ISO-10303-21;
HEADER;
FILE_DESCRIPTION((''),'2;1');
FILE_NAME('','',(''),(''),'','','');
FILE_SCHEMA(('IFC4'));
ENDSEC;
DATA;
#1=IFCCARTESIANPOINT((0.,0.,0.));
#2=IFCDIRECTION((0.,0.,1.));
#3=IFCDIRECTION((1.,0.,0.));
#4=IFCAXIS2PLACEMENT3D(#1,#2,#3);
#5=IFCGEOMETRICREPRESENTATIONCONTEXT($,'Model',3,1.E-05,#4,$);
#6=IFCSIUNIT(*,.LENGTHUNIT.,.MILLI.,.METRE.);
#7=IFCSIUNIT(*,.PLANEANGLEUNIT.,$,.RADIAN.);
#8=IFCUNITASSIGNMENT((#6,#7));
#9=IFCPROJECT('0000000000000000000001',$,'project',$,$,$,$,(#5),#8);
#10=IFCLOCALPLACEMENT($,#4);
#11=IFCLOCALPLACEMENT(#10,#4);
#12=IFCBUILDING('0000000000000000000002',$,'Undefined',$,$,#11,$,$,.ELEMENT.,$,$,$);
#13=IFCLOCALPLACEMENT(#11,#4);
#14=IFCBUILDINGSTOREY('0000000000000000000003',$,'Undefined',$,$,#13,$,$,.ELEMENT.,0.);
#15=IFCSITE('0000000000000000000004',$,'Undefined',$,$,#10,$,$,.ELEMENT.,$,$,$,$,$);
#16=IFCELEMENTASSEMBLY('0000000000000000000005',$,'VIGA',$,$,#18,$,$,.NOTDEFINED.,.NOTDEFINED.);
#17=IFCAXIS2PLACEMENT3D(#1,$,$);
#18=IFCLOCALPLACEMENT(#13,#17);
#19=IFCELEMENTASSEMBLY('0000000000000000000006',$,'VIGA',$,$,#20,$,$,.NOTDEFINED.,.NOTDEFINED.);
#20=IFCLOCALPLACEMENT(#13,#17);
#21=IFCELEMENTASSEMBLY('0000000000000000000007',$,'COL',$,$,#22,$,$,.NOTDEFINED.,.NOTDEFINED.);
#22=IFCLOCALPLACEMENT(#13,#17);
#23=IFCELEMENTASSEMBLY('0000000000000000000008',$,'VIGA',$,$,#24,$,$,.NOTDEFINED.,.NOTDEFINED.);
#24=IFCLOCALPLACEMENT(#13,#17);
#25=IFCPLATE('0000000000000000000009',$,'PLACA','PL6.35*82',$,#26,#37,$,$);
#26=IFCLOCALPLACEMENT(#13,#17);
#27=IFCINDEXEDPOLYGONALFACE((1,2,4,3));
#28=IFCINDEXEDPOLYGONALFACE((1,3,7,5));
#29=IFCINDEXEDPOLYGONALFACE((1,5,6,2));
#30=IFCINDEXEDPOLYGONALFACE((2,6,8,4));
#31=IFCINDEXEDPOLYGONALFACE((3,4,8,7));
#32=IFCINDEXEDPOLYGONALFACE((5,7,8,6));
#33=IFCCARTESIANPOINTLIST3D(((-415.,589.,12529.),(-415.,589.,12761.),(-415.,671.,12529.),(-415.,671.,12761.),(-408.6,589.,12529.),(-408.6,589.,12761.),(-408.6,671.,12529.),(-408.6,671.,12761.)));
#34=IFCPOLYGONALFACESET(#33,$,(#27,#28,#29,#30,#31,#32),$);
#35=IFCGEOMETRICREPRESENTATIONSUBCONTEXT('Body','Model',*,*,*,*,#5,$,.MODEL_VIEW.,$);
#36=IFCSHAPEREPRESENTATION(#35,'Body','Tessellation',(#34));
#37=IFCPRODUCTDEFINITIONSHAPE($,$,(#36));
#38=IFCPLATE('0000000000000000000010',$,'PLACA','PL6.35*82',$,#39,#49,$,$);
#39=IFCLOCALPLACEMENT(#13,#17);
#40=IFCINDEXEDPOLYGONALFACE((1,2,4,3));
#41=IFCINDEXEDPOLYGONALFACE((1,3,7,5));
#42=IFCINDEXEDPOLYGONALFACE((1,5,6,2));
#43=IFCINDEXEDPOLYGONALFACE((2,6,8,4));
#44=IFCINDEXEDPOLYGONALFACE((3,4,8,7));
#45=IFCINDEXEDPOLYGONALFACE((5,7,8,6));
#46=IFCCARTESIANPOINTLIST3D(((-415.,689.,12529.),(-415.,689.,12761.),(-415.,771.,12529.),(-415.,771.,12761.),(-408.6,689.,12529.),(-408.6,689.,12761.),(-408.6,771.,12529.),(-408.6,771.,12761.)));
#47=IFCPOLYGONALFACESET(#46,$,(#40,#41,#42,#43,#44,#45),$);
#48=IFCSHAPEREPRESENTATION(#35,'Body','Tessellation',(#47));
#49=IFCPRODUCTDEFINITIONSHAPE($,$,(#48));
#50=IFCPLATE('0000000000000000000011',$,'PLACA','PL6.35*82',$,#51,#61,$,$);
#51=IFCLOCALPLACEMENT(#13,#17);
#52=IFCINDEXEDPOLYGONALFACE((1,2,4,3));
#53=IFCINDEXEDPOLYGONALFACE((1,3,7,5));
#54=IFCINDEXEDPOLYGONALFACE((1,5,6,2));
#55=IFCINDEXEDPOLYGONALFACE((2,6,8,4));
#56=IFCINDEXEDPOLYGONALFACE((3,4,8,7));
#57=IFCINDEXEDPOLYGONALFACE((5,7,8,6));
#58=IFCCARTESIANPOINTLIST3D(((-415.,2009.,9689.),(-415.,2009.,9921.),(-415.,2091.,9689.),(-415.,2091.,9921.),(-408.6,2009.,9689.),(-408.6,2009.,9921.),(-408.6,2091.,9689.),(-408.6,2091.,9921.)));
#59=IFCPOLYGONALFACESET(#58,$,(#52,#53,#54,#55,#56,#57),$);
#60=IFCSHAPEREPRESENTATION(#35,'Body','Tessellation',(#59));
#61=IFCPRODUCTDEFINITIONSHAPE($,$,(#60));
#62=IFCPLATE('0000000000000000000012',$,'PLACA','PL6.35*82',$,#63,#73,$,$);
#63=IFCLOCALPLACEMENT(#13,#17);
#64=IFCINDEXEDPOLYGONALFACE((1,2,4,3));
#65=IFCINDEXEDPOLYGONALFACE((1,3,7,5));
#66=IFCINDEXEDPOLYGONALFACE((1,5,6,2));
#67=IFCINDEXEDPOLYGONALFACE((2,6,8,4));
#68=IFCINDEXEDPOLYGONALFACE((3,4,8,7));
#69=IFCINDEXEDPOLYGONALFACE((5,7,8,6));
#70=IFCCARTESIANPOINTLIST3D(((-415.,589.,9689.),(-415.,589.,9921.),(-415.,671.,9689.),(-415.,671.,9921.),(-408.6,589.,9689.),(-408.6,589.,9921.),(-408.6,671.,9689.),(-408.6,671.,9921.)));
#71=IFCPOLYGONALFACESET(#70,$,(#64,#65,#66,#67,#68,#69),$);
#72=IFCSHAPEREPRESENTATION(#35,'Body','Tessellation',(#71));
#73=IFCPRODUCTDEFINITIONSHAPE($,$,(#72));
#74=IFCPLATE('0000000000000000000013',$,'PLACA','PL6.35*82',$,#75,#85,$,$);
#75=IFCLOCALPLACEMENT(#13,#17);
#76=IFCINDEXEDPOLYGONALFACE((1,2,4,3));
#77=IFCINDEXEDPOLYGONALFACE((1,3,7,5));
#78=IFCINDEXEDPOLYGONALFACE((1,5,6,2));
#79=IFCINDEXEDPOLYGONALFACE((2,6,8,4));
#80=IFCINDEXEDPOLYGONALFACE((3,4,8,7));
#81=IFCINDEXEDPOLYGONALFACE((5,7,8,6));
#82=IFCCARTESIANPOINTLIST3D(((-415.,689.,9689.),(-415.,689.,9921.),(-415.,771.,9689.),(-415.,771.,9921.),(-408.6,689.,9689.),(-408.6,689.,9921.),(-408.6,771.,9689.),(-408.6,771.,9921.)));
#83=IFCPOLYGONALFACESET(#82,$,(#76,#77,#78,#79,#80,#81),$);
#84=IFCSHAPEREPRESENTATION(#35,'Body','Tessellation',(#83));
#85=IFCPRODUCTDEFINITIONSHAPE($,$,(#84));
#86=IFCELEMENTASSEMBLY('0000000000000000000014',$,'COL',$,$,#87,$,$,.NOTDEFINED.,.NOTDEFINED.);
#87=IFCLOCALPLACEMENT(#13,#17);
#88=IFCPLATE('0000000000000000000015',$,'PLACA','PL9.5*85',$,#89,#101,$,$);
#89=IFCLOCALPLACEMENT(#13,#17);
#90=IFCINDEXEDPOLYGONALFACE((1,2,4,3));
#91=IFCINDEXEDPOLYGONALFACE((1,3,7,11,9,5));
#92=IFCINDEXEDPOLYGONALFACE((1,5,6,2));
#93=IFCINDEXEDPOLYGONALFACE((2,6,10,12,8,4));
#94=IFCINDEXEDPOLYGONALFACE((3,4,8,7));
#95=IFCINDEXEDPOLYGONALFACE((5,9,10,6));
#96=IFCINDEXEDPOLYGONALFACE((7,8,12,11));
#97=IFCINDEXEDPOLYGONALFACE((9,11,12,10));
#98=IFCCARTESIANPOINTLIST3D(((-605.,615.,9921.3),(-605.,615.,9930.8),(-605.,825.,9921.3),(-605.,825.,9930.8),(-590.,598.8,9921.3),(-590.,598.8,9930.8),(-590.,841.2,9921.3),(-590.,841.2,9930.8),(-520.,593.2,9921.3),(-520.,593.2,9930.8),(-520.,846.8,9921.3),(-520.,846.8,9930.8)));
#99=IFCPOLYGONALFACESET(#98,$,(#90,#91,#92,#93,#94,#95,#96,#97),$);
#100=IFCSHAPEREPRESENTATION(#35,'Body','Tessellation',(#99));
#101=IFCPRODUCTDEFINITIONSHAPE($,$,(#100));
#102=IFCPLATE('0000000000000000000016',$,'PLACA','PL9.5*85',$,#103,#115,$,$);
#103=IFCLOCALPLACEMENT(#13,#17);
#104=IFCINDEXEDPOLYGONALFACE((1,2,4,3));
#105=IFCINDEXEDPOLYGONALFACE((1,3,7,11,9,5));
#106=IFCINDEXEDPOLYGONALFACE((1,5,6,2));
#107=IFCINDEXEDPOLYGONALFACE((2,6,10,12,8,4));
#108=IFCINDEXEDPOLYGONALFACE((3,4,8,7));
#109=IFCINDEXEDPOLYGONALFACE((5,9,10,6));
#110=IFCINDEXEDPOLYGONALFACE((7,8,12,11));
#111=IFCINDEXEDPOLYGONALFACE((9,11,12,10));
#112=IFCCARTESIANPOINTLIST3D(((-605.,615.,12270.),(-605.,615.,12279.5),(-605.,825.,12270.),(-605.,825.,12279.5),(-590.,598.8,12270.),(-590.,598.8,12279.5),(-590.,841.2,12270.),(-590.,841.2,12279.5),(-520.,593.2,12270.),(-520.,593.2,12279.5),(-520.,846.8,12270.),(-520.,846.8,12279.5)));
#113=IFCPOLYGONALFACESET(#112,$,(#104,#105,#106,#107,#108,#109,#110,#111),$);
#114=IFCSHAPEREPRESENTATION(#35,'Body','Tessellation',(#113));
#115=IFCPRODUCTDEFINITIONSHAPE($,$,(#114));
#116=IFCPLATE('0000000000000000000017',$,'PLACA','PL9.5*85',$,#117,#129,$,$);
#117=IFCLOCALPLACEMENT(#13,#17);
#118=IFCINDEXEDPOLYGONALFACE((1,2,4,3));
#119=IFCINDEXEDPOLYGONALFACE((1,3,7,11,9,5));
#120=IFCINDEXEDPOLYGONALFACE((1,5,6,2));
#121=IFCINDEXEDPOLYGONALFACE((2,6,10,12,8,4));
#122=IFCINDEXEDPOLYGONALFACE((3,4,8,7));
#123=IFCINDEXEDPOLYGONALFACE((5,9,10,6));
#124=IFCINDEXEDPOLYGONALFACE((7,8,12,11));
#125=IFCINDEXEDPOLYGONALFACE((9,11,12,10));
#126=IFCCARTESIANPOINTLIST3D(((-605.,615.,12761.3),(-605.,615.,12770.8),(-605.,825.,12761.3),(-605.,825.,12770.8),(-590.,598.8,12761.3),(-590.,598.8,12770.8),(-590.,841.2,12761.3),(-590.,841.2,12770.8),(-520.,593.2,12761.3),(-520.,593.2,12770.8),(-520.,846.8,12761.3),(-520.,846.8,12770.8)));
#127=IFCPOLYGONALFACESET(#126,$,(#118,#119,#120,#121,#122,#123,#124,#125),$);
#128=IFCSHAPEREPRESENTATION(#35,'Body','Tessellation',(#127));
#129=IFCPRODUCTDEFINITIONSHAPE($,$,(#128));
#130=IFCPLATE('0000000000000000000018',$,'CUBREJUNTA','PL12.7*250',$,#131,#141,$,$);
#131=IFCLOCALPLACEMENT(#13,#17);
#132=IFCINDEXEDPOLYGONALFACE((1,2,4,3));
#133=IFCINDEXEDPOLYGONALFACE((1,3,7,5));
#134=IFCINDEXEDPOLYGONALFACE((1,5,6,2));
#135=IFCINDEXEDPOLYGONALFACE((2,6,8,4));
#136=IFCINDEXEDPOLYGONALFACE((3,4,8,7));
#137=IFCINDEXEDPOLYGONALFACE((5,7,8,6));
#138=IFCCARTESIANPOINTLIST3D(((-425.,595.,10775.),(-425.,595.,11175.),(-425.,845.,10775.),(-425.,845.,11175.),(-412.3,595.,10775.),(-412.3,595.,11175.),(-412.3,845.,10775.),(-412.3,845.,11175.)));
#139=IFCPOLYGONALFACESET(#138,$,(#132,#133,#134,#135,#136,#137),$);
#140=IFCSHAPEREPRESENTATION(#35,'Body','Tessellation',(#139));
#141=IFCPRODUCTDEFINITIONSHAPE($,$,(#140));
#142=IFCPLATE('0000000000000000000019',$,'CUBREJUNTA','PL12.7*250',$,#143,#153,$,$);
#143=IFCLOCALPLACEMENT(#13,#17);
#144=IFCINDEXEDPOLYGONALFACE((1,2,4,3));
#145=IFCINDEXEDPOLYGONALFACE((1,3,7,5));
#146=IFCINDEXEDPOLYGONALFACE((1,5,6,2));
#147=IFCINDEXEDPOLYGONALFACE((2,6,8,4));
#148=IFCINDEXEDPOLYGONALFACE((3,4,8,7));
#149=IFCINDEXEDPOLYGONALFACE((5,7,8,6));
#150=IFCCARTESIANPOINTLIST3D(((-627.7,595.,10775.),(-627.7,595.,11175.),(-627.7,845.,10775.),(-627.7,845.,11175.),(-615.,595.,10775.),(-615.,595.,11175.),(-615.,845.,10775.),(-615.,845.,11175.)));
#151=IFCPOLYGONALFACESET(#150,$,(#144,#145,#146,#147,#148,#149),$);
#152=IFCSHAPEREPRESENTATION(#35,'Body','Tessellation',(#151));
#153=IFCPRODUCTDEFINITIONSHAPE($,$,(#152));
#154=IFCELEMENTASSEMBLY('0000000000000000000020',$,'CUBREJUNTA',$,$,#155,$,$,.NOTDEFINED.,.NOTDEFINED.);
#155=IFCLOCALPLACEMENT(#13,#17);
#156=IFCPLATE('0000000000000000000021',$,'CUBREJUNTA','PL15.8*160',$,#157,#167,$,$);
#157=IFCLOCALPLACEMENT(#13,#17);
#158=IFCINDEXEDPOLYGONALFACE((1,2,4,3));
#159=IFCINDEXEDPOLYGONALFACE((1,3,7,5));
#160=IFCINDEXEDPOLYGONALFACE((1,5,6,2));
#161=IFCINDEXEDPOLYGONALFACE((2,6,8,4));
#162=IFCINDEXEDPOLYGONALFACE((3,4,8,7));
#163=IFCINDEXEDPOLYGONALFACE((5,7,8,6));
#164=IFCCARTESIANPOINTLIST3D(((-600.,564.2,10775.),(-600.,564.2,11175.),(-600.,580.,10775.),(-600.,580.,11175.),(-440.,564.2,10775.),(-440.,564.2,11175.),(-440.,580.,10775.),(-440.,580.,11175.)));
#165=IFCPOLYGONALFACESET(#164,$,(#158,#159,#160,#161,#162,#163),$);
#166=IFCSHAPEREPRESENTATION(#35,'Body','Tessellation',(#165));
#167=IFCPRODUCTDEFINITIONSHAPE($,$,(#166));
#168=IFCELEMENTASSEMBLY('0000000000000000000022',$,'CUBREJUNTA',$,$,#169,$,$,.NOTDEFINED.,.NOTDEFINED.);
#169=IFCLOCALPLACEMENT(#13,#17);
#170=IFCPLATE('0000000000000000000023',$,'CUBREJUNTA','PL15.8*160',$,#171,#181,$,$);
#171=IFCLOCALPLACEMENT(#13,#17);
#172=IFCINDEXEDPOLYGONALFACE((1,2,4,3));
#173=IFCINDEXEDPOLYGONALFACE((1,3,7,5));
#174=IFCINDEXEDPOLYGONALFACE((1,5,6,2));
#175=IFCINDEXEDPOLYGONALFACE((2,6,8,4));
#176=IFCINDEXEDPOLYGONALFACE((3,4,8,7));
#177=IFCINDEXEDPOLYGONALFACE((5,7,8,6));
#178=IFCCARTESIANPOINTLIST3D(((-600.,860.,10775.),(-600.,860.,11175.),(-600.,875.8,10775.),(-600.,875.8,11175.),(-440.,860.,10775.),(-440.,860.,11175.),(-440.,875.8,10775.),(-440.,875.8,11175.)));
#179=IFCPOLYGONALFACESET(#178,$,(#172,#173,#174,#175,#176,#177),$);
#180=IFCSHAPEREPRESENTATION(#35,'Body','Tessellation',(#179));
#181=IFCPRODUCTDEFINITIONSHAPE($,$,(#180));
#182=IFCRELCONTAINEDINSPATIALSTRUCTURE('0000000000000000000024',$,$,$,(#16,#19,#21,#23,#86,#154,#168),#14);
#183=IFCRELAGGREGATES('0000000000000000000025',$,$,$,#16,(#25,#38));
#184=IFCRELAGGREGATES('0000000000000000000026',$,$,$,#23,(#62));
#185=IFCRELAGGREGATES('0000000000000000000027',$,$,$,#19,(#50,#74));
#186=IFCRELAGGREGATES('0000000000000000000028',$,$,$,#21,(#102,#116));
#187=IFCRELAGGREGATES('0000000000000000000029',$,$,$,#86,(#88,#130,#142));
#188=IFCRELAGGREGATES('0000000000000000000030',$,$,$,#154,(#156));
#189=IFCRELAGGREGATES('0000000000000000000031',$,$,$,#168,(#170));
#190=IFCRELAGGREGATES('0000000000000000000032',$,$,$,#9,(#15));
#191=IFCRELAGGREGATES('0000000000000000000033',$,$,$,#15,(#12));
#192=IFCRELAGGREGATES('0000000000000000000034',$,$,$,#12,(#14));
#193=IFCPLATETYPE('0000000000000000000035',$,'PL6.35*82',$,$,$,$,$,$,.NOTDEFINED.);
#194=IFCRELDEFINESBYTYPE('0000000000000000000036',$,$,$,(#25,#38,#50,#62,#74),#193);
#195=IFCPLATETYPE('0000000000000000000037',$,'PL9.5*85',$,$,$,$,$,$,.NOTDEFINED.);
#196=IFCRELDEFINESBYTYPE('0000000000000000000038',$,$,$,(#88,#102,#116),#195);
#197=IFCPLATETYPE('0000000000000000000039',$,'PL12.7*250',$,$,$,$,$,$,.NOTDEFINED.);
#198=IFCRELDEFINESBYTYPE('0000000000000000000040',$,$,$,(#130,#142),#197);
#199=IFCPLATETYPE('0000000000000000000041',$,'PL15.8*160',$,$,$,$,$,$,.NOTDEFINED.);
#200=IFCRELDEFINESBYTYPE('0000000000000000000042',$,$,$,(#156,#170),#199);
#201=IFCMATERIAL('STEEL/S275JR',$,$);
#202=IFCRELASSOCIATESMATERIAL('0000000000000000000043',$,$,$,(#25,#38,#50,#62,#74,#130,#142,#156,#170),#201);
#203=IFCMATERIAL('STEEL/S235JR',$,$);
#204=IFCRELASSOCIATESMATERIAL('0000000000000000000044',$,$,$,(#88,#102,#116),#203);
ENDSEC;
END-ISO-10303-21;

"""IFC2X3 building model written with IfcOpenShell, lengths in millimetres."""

from ifc_helpers import new_model, si_unit, frame, origin_with_axes, place, context, subcontext, project, spatial, polyline, outline, extrude, material, type_object, element, aggregate, save


model = new_model("IFC2X3")

# Units and contexts
model_context = context("Model", 3, precision=1e-05, world=origin_with_axes())
body_context = subcontext(model_context, "Body", "Model", "MODEL_VIEW")
ifc_project = project(units=[si_unit("LENGTHUNIT", "METRE", prefix="MILLI"), si_unit("PLANEANGLEUNIT", "RADIAN")], contexts=[model_context])

# Site, building, storey
site_placement = place(None, origin_with_axes())
site = spatial("IfcSite", under=ifc_project, at=site_placement, Name="Undefined", CompositionType="ELEMENT")
building_placement = place(site_placement, origin_with_axes())
building = spatial("IfcBuilding", under=site, at=building_placement, Name="Undefined", CompositionType="ELEMENT")
storey_placement = place(building_placement, origin_with_axes())
storey = spatial("IfcBuildingStorey", under=building, at=storey_placement, Name="Undefined", CompositionType="ELEMENT", Elevation=0.0)

# Element assembly
assembly_1_placement = place(storey_placement, origin_with_axes())
assembly_1 = element("IfcElementAssembly", 1, at=assembly_1_placement, inside=storey, Name="VIGA", AssemblyPlace="NOTDEFINED", PredefinedType="NOTDEFINED")
ifc_material_1 = material(Name="STEEL/S235JR")

# Element assembly
assembly_2_placement = place(storey_placement, origin_with_axes())
assembly_2 = element("IfcElementAssembly", 2, at=assembly_2_placement, inside=storey, Name="VIGA", AssemblyPlace="NOTDEFINED", PredefinedType="NOTDEFINED")

# Element assemblies
assembly_3_placement = place(storey_placement, origin_with_axes())
assembly_3 = element("IfcElementAssembly", 3, at=assembly_3_placement, inside=storey, Name="COL", AssemblyPlace="NOTDEFINED", PredefinedType="NOTDEFINED")
ifc_material_2 = material(Name="STEEL/S275JR")
assembly_4_placement = place(storey_placement, origin_with_axes())
assembly_4 = element("IfcElementAssembly", 4, at=assembly_4_placement, inside=storey, Name="VIGA", AssemblyPlace="NOTDEFINED", PredefinedType="NOTDEFINED")

# Plates
plate_type_1 = type_object("IfcPlateType", Name="PL6.35*82", PredefinedType="NOTDEFINED")
plate_1_placement = place(assembly_1_placement, frame((-411.8, 589.0, 12761.0), z_axis=(-1.0, 0.0, 0.0), x_axis=(0.0, 1.0, 0.0)))
plate_1 = element("IfcPlate", 5, at=plate_1_placement, type_object=plate_type_1, material=ifc_material_2, Name="PLACA", Description="PL6.35*82", context=body_context, shape_type="SweptSolid", body=[
    extrude(outline(polyline([(0.0, 0.0), (82.0, 0.0), (82.0, 232.0), (0.0, 232.0), (0.0, 0.0)])), frame((0.0, 0.0, -3.2), z_axis=(0.0, 0.0, 1.0), x_axis=(1.0, 0.0, 0.0)), (0.0, 0.0, 1.0), 6.4),
])
plate_2_placement = place(assembly_1_placement, frame((-411.8, 689.0, 12761.0), z_axis=(-1.0, 0.0, 0.0), x_axis=(0.0, 1.0, 0.0)))
plate_2 = element("IfcPlate", 6, at=plate_2_placement, type_object=plate_type_1, material=ifc_material_2, Name="PLACA", Description="PL6.35*82", context=body_context, shape_type="SweptSolid", body=[
    extrude(outline(polyline([(0.0, 0.0), (82.0, 0.0), (82.0, 232.0), (0.0, 232.0), (0.0, 0.0)])), frame((0.0, 0.0, -3.2), z_axis=(0.0, 0.0, 1.0), x_axis=(1.0, 0.0, 0.0)), (0.0, 0.0, 1.0), 6.4),
])
aggregate(assembly_1, [plate_1, plate_2])
plate_3_placement = place(assembly_2_placement, frame((-411.8, 2009.0, 9921.0), z_axis=(-1.0, 0.0, 0.0), x_axis=(0.0, 1.0, 0.0)))
plate_3 = element("IfcPlate", 7, at=plate_3_placement, type_object=plate_type_1, material=ifc_material_2, Name="PLACA", Description="PL6.35*82", context=body_context, shape_type="SweptSolid", body=[
    extrude(outline(polyline([(0.0, 0.0), (82.0, 0.0), (82.0, 232.0), (0.0, 232.0), (0.0, 0.0)])), frame((0.0, 0.0, -3.2), z_axis=(0.0, 0.0, 1.0), x_axis=(1.0, 0.0, 0.0)), (0.0, 0.0, 1.0), 6.4),
])
plate_4_placement = place(assembly_4_placement, frame((-411.8, 589.0, 9921.0), z_axis=(-1.0, 0.0, 0.0), x_axis=(0.0, 1.0, 0.0)))
plate_4 = element("IfcPlate", 8, at=plate_4_placement, type_object=plate_type_1, material=ifc_material_2, Name="PLACA", Description="PL6.35*82", context=body_context, shape_type="SweptSolid", body=[
    extrude(outline(polyline([(0.0, 0.0), (82.0, 0.0), (82.0, 232.0), (0.0, 232.0), (0.0, 0.0)])), frame((0.0, 0.0, -3.2), z_axis=(0.0, 0.0, 1.0), x_axis=(1.0, 0.0, 0.0)), (0.0, 0.0, 1.0), 6.4),
])
aggregate(assembly_4, [plate_4])
plate_5_placement = place(assembly_2_placement, frame((-411.8, 689.0, 9921.0), z_axis=(-1.0, 0.0, 0.0), x_axis=(0.0, 1.0, 0.0)))
plate_5 = element("IfcPlate", 9, at=plate_5_placement, type_object=plate_type_1, material=ifc_material_2, Name="PLACA", Description="PL6.35*82", context=body_context, shape_type="SweptSolid", body=[
    extrude(outline(polyline([(0.0, 0.0), (82.0, 0.0), (82.0, 232.0), (0.0, 232.0), (0.0, 0.0)])), frame((0.0, 0.0, -3.2), z_axis=(0.0, 0.0, 1.0), x_axis=(1.0, 0.0, 0.0)), (0.0, 0.0, 1.0), 6.4),
])
aggregate(assembly_2, [plate_3, plate_5])

# Element assembly, plate
assembly_5_placement = place(storey_placement, origin_with_axes())
assembly_5 = element("IfcElementAssembly", 10, at=assembly_5_placement, inside=storey, Name="COL", AssemblyPlace="NOTDEFINED", PredefinedType="NOTDEFINED")
plate_type_2 = type_object("IfcPlateType", Name="PL9.5*85", PredefinedType="NOTDEFINED")
plate_6_placement = place(assembly_5_placement, frame((-520.0, 846.8, 9926.0), z_axis=(0.0, 0.0, 1.0), x_axis=(-0.996815, -0.079745, 0.0)))
plate_6 = element("IfcPlate", 11, at=plate_6_placement, type_object=plate_type_2, material=ifc_material_1, Name="PLACA", Description="PL9.5*85", context=body_context, shape_type="SweptSolid", body=[
    extrude(outline(polyline([(0.0, 0.0), (70.3, 0.0), (86.5, 15.0), (103.2, 224.3), (89.6, 241.6), (20.2, 252.8), (0.0, 0.0)])), frame((0.0, 0.0, -4.7), z_axis=(0.0, 0.0, 1.0), x_axis=(1.0, 0.0, 0.0)), (0.0, 0.0, 1.0), 9.5),
])

# Plates
plate_7_placement = place(assembly_3_placement, frame((-520.0, 846.8, 12274.8), z_axis=(0.0, 0.0, 1.0), x_axis=(-0.996815, -0.079745, 0.0)))
plate_7 = element("IfcPlate", 12, at=plate_7_placement, type_object=plate_type_2, material=ifc_material_1, Name="PLACA", Description="PL9.5*85", context=body_context, shape_type="SweptSolid", body=[
    extrude(outline(polyline([(0.0, 0.0), (70.3, 0.0), (86.5, 15.0), (103.2, 224.3), (89.6, 241.6), (20.2, 252.8), (0.0, 0.0)])), frame((0.0, 0.0, -4.7), z_axis=(0.0, 0.0, 1.0), x_axis=(1.0, 0.0, 0.0)), (0.0, 0.0, 1.0), 9.5),
])
plate_8_placement = place(assembly_3_placement, frame((-520.0, 846.8, 12766.0), z_axis=(0.0, 0.0, 1.0), x_axis=(-0.996815, -0.079745, 0.0)))
plate_8 = element("IfcPlate", 13, at=plate_8_placement, type_object=plate_type_2, material=ifc_material_1, Name="PLACA", Description="PL9.5*85", context=body_context, shape_type="SweptSolid", body=[
    extrude(outline(polyline([(0.0, 0.0), (70.3, 0.0), (86.5, 15.0), (103.2, 224.3), (89.6, 241.6), (20.2, 252.8), (0.0, 0.0)])), frame((0.0, 0.0, -4.7), z_axis=(0.0, 0.0, 1.0), x_axis=(1.0, 0.0, 0.0)), (0.0, 0.0, 1.0), 9.5),
])
aggregate(assembly_3, [plate_7, plate_8])
plate_type_3 = type_object("IfcPlateType", Name="PL12.7*250", PredefinedType="NOTDEFINED")
plate_9_placement = place(assembly_5_placement, frame((-418.7, 845.0, 11175.0), z_axis=(-1.0, 0.0, 0.0), x_axis=(0.0, 0.0, -1.0)))
plate_9 = element("IfcPlate", 14, at=plate_9_placement, type_object=plate_type_3, material=ifc_material_2, Name="CUBREJUNTA", Description="PL12.7*250", context=body_context, shape_type="SweptSolid", body=[
    extrude(outline(polyline([(0.0, 0.0), (400.0, 0.0), (400.0, 250.0), (0.0, 250.0), (0.0, 0.0)])), frame((0.0, 0.0, -6.3), z_axis=(0.0, 0.0, 1.0), x_axis=(1.0, 0.0, 0.0)), (0.0, 0.0, 1.0), 12.7),
])
plate_10_placement = place(assembly_5_placement, frame((-621.3, 845.0, 11175.0), z_axis=(-1.0, 0.0, 0.0), x_axis=(0.0, 0.0, -1.0)))
plate_10 = element("IfcPlate", 15, at=plate_10_placement, type_object=plate_type_3, material=ifc_material_2, Name="CUBREJUNTA", Description="PL12.7*250", context=body_context, shape_type="SweptSolid", body=[
    extrude(outline(polyline([(0.0, 0.0), (400.0, 0.0), (400.0, 250.0), (0.0, 250.0), (0.0, 0.0)])), frame((0.0, 0.0, -6.3), z_axis=(0.0, 0.0, 1.0), x_axis=(1.0, 0.0, 0.0)), (0.0, 0.0, 1.0), 12.7),
])
aggregate(assembly_5, [plate_6, plate_9, plate_10])

# Element assemblies, plates
assembly_6_placement = place(storey_placement, origin_with_axes())
assembly_6 = element("IfcElementAssembly", 16, at=assembly_6_placement, inside=storey, Name="CUBREJUNTA", AssemblyPlace="NOTDEFINED", PredefinedType="NOTDEFINED")
plate_type_4 = type_object("IfcPlateType", Name="PL15.8*160", PredefinedType="NOTDEFINED")
plate_11_placement = place(assembly_6_placement, frame((-440.0, 572.1, 10775.0), z_axis=(0.0, 1.0, 0.0), x_axis=(-1.0, 0.0, 0.0)))
plate_11 = element("IfcPlate", 17, at=plate_11_placement, type_object=plate_type_4, material=ifc_material_2, Name="CUBREJUNTA", Description="PL15.8*160", context=body_context, shape_type="SweptSolid", body=[
    extrude(outline(polyline([(0.0, 0.0), (160.0, 0.0), (160.0, 400.0), (0.0, 400.0), (0.0, 0.0)])), frame((0.0, 0.0, -7.9), z_axis=(0.0, 0.0, 1.0), x_axis=(1.0, 0.0, 0.0)), (0.0, 0.0, 1.0), 15.8),
])
aggregate(assembly_6, [plate_11])
assembly_7_placement = place(storey_placement, origin_with_axes())
assembly_7 = element("IfcElementAssembly", 18, at=assembly_7_placement, inside=storey, Name="CUBREJUNTA", AssemblyPlace="NOTDEFINED", PredefinedType="NOTDEFINED")
plate_12_placement = place(assembly_7_placement, frame((-440.0, 867.9, 10775.0), z_axis=(0.0, 1.0, 0.0), x_axis=(-1.0, 0.0, 0.0)))
plate_12 = element("IfcPlate", 19, at=plate_12_placement, type_object=plate_type_4, material=ifc_material_2, Name="CUBREJUNTA", Description="PL15.8*160", context=body_context, shape_type="SweptSolid", body=[
    extrude(outline(polyline([(0.0, 0.0), (160.0, 0.0), (160.0, 400.0), (0.0, 400.0), (0.0, 0.0)])), frame((0.0, 0.0, -7.9), z_axis=(0.0, 0.0, 1.0), x_axis=(1.0, 0.0, 0.0)), (0.0, 0.0, 1.0), 15.8),
])
aggregate(assembly_7, [plate_12])

save(model, "model.ifc")
